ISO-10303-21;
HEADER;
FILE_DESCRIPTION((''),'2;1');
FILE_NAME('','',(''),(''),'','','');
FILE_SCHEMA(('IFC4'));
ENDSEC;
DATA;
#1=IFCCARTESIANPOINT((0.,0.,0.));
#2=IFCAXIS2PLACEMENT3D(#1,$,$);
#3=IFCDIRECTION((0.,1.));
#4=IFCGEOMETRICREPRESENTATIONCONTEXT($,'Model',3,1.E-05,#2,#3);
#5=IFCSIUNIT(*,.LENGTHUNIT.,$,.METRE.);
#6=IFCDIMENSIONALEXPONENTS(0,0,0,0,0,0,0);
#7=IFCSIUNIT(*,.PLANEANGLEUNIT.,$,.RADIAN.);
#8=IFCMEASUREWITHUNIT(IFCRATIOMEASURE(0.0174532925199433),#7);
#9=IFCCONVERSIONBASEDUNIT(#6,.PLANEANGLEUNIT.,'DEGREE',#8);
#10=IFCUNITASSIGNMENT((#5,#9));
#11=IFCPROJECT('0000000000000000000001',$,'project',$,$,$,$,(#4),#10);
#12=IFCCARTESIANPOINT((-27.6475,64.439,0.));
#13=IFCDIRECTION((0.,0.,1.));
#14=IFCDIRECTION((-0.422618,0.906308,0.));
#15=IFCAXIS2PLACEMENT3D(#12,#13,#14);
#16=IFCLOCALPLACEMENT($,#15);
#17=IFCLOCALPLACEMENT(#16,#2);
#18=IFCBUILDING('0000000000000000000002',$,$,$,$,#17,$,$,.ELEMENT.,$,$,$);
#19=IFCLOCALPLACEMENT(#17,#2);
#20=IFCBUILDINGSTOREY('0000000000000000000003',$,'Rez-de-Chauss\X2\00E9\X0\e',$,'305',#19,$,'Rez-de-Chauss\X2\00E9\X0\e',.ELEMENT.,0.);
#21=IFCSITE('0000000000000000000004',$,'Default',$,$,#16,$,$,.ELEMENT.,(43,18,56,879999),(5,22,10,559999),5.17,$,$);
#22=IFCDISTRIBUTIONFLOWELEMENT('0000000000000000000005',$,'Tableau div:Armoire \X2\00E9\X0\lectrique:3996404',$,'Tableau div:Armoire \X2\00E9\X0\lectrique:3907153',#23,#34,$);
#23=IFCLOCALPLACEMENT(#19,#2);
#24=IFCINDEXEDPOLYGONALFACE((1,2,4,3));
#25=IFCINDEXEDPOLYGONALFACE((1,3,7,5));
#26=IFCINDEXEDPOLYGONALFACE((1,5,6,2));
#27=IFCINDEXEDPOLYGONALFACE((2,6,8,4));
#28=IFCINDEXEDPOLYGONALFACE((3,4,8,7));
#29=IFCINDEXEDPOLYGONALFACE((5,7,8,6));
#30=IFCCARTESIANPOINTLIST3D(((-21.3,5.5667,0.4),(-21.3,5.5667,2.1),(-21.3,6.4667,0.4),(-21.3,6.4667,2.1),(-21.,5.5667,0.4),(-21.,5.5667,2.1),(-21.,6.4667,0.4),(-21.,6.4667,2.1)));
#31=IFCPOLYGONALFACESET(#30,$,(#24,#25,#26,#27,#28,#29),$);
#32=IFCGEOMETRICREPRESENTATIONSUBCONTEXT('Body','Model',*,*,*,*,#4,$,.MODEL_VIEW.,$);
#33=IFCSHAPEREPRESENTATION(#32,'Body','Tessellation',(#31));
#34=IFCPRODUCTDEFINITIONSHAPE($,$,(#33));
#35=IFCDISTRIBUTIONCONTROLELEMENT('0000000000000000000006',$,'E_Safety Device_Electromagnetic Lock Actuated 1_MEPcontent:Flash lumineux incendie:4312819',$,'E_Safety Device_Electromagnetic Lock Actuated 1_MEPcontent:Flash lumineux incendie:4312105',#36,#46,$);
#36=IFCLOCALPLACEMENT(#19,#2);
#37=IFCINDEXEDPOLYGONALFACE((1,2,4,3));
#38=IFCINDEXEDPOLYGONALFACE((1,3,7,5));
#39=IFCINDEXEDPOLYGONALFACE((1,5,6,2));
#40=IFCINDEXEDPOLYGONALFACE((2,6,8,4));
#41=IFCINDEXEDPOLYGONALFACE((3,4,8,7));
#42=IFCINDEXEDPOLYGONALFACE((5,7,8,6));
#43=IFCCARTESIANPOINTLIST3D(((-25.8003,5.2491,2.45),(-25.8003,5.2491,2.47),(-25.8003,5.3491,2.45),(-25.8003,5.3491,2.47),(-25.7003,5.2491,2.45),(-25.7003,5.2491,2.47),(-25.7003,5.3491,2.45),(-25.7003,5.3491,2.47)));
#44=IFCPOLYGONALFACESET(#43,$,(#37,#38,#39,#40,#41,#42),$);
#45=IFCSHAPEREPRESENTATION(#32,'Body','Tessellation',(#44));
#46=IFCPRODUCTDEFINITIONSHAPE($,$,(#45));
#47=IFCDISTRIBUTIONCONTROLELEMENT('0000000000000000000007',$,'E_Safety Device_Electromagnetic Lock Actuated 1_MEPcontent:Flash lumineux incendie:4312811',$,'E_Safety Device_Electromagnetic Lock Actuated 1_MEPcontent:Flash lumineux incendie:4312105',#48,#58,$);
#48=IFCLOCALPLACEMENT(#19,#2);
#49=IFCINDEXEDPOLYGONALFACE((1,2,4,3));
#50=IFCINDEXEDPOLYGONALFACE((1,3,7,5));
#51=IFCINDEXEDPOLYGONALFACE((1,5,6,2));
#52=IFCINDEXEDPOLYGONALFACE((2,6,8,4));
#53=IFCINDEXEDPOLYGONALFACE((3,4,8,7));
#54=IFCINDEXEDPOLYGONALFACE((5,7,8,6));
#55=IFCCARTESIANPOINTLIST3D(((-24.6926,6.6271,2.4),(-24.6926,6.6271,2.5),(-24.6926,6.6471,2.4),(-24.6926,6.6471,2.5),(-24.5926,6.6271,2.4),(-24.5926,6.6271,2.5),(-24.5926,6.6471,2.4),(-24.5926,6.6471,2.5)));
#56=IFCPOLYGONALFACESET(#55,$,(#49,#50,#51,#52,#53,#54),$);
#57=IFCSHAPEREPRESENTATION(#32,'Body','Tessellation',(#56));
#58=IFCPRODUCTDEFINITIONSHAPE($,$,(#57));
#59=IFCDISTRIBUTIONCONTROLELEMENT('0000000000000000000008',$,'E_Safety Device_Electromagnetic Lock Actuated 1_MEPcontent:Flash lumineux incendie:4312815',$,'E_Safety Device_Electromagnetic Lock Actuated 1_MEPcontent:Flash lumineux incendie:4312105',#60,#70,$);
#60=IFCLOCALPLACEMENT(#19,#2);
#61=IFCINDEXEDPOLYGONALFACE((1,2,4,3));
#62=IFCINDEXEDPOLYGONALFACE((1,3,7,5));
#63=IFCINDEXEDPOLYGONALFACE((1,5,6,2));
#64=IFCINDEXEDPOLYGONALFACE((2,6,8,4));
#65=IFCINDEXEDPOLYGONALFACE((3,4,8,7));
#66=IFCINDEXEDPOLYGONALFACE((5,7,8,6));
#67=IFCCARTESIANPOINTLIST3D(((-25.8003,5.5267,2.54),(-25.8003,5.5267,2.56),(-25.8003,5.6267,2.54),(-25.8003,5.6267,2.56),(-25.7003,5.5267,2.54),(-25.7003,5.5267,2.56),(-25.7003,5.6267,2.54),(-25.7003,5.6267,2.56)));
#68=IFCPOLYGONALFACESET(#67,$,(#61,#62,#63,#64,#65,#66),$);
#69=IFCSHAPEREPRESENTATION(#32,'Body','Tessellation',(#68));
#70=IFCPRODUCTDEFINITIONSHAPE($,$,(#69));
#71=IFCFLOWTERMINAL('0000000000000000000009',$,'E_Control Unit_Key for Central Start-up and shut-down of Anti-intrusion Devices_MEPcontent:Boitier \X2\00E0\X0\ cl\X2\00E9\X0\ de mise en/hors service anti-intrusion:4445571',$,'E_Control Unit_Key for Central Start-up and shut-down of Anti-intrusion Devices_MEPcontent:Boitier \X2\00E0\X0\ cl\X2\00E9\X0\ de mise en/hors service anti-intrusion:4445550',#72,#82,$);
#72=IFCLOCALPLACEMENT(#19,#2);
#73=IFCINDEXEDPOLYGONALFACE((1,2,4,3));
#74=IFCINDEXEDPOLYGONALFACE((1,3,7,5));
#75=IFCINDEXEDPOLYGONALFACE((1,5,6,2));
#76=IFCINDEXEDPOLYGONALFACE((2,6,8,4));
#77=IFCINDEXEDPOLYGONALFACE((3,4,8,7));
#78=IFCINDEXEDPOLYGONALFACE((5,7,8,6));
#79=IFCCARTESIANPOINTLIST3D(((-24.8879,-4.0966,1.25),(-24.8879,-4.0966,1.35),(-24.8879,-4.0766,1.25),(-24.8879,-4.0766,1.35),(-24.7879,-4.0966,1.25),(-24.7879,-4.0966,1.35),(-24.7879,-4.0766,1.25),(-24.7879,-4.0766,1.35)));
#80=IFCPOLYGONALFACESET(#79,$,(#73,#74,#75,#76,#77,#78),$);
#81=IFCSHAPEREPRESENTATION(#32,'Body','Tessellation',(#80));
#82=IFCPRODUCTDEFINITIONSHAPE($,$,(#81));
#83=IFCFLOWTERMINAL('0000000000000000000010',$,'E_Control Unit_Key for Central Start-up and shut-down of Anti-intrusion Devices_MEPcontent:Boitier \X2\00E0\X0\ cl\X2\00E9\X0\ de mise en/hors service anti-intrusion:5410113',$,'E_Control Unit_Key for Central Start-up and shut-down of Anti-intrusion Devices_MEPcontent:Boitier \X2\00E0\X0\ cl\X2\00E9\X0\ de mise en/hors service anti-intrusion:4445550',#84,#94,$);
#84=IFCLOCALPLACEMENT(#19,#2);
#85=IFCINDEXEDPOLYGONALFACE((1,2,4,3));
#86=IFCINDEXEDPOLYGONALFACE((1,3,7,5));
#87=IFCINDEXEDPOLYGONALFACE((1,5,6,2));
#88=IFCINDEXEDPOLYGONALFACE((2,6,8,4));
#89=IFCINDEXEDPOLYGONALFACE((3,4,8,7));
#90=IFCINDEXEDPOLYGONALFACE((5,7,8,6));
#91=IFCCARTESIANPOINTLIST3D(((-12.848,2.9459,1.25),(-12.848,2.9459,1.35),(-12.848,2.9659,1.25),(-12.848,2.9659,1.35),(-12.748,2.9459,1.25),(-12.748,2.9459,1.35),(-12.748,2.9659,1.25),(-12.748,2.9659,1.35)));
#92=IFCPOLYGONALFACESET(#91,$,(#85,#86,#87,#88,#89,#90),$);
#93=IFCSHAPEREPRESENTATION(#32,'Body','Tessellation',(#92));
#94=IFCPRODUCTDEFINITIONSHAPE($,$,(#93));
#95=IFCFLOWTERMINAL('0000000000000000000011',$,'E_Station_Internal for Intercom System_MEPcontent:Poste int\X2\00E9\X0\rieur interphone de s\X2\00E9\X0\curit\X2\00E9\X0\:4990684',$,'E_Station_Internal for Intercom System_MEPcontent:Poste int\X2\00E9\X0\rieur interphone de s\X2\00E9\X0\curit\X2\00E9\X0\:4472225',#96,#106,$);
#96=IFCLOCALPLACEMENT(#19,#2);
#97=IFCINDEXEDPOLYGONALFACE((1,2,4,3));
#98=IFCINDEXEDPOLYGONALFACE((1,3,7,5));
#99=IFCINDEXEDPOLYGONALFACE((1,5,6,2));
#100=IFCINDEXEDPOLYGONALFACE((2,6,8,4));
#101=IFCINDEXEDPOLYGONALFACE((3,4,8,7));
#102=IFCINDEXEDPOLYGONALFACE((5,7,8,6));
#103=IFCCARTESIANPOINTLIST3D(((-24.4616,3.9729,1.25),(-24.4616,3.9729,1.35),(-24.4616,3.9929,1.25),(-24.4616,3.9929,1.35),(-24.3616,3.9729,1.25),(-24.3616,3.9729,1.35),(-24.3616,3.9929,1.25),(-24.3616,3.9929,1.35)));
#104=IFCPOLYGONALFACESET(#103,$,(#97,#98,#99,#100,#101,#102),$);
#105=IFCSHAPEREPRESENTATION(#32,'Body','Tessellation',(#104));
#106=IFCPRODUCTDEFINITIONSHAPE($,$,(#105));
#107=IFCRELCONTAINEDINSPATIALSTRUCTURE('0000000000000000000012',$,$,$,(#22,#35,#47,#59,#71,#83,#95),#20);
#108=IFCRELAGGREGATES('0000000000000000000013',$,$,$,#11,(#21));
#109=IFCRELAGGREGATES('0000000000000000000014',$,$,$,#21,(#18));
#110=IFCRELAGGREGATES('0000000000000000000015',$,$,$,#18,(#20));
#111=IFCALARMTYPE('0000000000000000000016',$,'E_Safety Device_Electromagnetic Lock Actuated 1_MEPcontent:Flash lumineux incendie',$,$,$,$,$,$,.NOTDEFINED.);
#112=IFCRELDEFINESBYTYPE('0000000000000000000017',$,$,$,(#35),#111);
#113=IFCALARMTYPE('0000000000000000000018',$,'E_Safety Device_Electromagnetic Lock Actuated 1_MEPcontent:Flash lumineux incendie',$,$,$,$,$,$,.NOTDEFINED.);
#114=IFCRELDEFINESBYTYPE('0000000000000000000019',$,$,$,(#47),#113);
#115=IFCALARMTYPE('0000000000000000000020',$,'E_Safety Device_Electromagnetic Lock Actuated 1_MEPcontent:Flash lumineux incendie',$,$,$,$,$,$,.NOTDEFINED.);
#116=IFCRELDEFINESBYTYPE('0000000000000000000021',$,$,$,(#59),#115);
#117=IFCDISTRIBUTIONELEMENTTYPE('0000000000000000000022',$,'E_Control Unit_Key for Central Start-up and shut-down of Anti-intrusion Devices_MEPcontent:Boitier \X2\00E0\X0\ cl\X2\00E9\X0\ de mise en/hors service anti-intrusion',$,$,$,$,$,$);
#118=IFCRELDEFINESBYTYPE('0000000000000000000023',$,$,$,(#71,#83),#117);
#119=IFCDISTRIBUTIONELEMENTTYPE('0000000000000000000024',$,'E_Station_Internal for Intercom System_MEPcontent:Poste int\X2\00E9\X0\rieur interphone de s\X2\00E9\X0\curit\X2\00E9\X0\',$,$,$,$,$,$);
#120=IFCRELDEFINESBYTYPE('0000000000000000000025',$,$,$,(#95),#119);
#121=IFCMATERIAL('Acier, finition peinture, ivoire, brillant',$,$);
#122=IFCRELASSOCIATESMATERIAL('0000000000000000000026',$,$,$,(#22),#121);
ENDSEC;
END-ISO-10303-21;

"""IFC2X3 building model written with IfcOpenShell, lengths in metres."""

from ifc_helpers import new_model, entity, si_unit, converted_unit, direction, frame, frame_2d, origin, origin_2d_with_axis, place, context, subcontext, project, spatial, rectangle, extrude, source, transform, mapped, material, type_object, type_shapes, element, save


model = new_model("IFC2X3")

# Units and contexts
model_context = context("Model", 3, precision=1e-05, world=origin(), true_north=direction((0.0, 1.0)))
body_context = subcontext(model_context, "Body", "Model", "MODEL_VIEW")
ifc_project = project(units=[si_unit("LENGTHUNIT", "METRE"), converted_unit("PLANEANGLEUNIT", "DEGREE", entity("IfcRatioMeasure", 0.0174532925199433), si_unit("PLANEANGLEUNIT", "RADIAN"), dimensions=[0, 0, 0, 0, 0, 0, 0])], contexts=[model_context])

# Site, building, storey
site_placement = place(None, frame((-27.6475, 64.439, 0.0), z_axis=(0.0, 0.0, 1.0), x_axis=(-0.422618, 0.906308, 0.0)))
site = spatial("IfcSite", under=ifc_project, at=site_placement, Name="Default", CompositionType="ELEMENT", RefLatitude=(43, 18, 56, 879999), RefLongitude=(5, 22, 10, 559999), RefElevation=5.17)
building_placement = place(site_placement, origin())
building = spatial("IfcBuilding", under=site, at=building_placement, CompositionType="ELEMENT")
storey_placement = place(building_placement, origin())
storey = spatial("IfcBuildingStorey", under=building, at=storey_placement, Name="Rez-de-Chaussée", ObjectType="305", LongName="Rez-de-Chaussée", CompositionType="ELEMENT", Elevation=0.0)

# Distribution flow element
ifc_material_1 = material(Name="Acier, finition peinture, ivoire, brillant")
shared_shape_1 = source(origin(), body_context, "Body", "SweptSolid", [
    extrude(rectangle(XDim=0.9, YDim=0.3, at=origin_2d_with_axis()), frame((0.0, -0.45, 0.0), z_axis=(0.0, 0.0, 1.0), x_axis=(0.0, 1.0, 0.0)), (0.0, 0.0, 1.0), 1.7),
])
distribution_flow_element_placement = place(storey_placement, frame((-21.15, 5.5667, 0.4), z_axis=(0.0, 0.0, 1.0), x_axis=(-1.0, 0.0, 0.0)))
element("IfcDistributionFlowElement", 1, at=distribution_flow_element_placement, inside=storey, material=ifc_material_1, Name="Tableau div:Armoire électrique:3996404", ObjectType="Tableau div:Armoire électrique:3907153", context=body_context, shape_type="MappedRepresentation", body=[
    mapped(shared_shape_1, transform((0.0, 0.0, 0.0), scale=1.0)),
])

# Distribution control elements
alarm_type_1 = type_object("IfcAlarmType", Name="E_Safety Device_Electromagnetic Lock Actuated 1_MEPcontent:Flash lumineux incendie", PredefinedType="NOTDEFINED")
shared_shape_2 = source(origin(), body_context, "Body", "SweptSolid", [
    extrude(rectangle(XDim=0.1, YDim=0.1, at=origin_2d_with_axis()), frame((0.0, 0.0, 0.0), z_axis=(0.0, 0.0, 1.0), x_axis=(0.0, -1.0, 0.0)), (0.0, 0.0, 1.0), 0.02),
])
type_shapes(alarm_type_1, [shared_shape_2])
distribution_control_element_1_placement = place(storey_placement, frame((-25.7503, 5.2991, 2.45), z_axis=(0.0, 0.0, 1.0), x_axis=(0.0, -1.0, 0.0)))
element("IfcDistributionControlElement", 2, at=distribution_control_element_1_placement, inside=storey, type_object=alarm_type_1, Name="E_Safety Device_Electromagnetic Lock Actuated 1_MEPcontent:Flash lumineux incendie:4312819", ObjectType="E_Safety Device_Electromagnetic Lock Actuated 1_MEPcontent:Flash lumineux incendie:4312105", context=body_context, shape_type="MappedRepresentation", body=[
    mapped(shared_shape_2, transform((0.0, 0.0, 0.0), scale=1.0)),
])
alarm_type_2 = type_object("IfcAlarmType", Name="E_Safety Device_Electromagnetic Lock Actuated 1_MEPcontent:Flash lumineux incendie", PredefinedType="NOTDEFINED")
shared_shape_3 = source(origin(), body_context, "Body", "SweptSolid", [
    extrude(rectangle(XDim=0.02, YDim=0.1, at=frame_2d((0.0, 0.0), x_axis=(1.0, 0.0))), frame((0.01, 0.0, -0.05), z_axis=(0.0, 0.0, 1.0), x_axis=(-1.0, 0.0, 0.0)), (0.0, 0.0, 1.0), 0.1),
])
type_shapes(alarm_type_2, [shared_shape_3])
distribution_control_element_2_placement = place(storey_placement, frame((-24.6426, 6.6471, 2.45), z_axis=(0.0, 0.0, 1.0), x_axis=(0.0, -1.0, 0.0)))
element("IfcDistributionControlElement", 3, at=distribution_control_element_2_placement, inside=storey, type_object=alarm_type_2, Name="E_Safety Device_Electromagnetic Lock Actuated 1_MEPcontent:Flash lumineux incendie:4312811", ObjectType="E_Safety Device_Electromagnetic Lock Actuated 1_MEPcontent:Flash lumineux incendie:4312105", context=body_context, shape_type="MappedRepresentation", body=[
    mapped(shared_shape_3, transform((0.0, 0.0, 0.0), scale=1.0)),
])
alarm_type_3 = type_object("IfcAlarmType", Name="E_Safety Device_Electromagnetic Lock Actuated 1_MEPcontent:Flash lumineux incendie", PredefinedType="NOTDEFINED")
shared_shape_4 = source(origin(), body_context, "Body", "SweptSolid", [
    extrude(rectangle(XDim=0.1, YDim=0.1, at=origin_2d_with_axis()), frame((0.0, 0.0, -0.02)), (0.0, 0.0, 1.0), 0.02),
])
type_shapes(alarm_type_3, [shared_shape_4])
distribution_control_element_3_placement = place(storey_placement, frame((-25.7503, 5.5767, 2.56), z_axis=(0.0, 0.0, 1.0), x_axis=(0.0, -1.0, 0.0)))
element("IfcDistributionControlElement", 4, at=distribution_control_element_3_placement, inside=storey, type_object=alarm_type_3, Name="E_Safety Device_Electromagnetic Lock Actuated 1_MEPcontent:Flash lumineux incendie:4312815", ObjectType="E_Safety Device_Electromagnetic Lock Actuated 1_MEPcontent:Flash lumineux incendie:4312105", context=body_context, shape_type="MappedRepresentation", body=[
    mapped(shared_shape_4, transform((0.0, 0.0, 0.0), scale=1.0)),
])

# Flow terminals
distribution_element_type_1 = type_object("IfcDistributionElementType", Name="E_Control Unit_Key for Central Start-up and shut-down of Anti-intrusion Devices_MEPcontent:Boitier à clé de mise en/hors service anti-intrusion")
shared_shape_5 = source(origin(), body_context, "Body", "SweptSolid", [
    extrude(rectangle(XDim=0.02, YDim=0.1, at=frame_2d((0.0, 0.0), x_axis=(1.0, 0.0))), frame((0.0, -0.01, -0.05), z_axis=(0.0, 0.0, 1.0), x_axis=(0.0, 1.0, 0.0)), (0.0, 0.0, 1.0), 0.1),
])
type_shapes(distribution_element_type_1, [shared_shape_5])
flow_terminal_1_placement = place(storey_placement, frame((-24.8379, -4.0966, 1.3), z_axis=(0.0, 0.0, 1.0), x_axis=(-1.0, 0.0, 0.0)))
element("IfcFlowTerminal", 5, at=flow_terminal_1_placement, inside=storey, type_object=distribution_element_type_1, Name="E_Control Unit_Key for Central Start-up and shut-down of Anti-intrusion Devices_MEPcontent:Boitier à clé de mise en/hors service anti-intrusion:4445571", ObjectType="E_Control Unit_Key for Central Start-up and shut-down of Anti-intrusion Devices_MEPcontent:Boitier à clé de mise en/hors service anti-intrusion:4445550", context=body_context, shape_type="MappedRepresentation", body=[
    mapped(shared_shape_5, transform((0.0, 0.0, 0.0), scale=1.0)),
])
flow_terminal_2_placement = place(storey_placement, frame((-12.798, 2.9659, 1.3)))
element("IfcFlowTerminal", 6, at=flow_terminal_2_placement, inside=storey, type_object=distribution_element_type_1, Name="E_Control Unit_Key for Central Start-up and shut-down of Anti-intrusion Devices_MEPcontent:Boitier à clé de mise en/hors service anti-intrusion:5410113", ObjectType="E_Control Unit_Key for Central Start-up and shut-down of Anti-intrusion Devices_MEPcontent:Boitier à clé de mise en/hors service anti-intrusion:4445550", context=body_context, shape_type="MappedRepresentation", body=[
    mapped(shared_shape_5, transform((0.0, 0.0, 0.0), scale=1.0)),
])
distribution_element_type_2 = type_object("IfcDistributionElementType", Name="E_Station_Internal for Intercom System_MEPcontent:Poste intérieur interphone de sécurité")
shared_shape_6 = source(origin(), body_context, "Body", "SweptSolid", [
    extrude(rectangle(XDim=0.02, YDim=0.1, at=frame_2d((0.0, 0.0), x_axis=(1.0, 0.0))), frame((0.0, -0.01, -0.05), z_axis=(0.0, 0.0, 1.0), x_axis=(0.0, 1.0, 0.0)), (0.0, 0.0, 1.0), 0.1),
])
type_shapes(distribution_element_type_2, [shared_shape_6])
flow_terminal_3_placement = place(storey_placement, frame((-24.4116, 3.9929, 1.3)))
element("IfcFlowTerminal", 7, at=flow_terminal_3_placement, inside=storey, type_object=distribution_element_type_2, Name="E_Station_Internal for Intercom System_MEPcontent:Poste intérieur interphone de sécurité:4990684", ObjectType="E_Station_Internal for Intercom System_MEPcontent:Poste intérieur interphone de sécurité:4472225", context=body_context, shape_type="MappedRepresentation", body=[
    mapped(shared_shape_6, transform((0.0, 0.0, 0.0), scale=1.0)),
])

save(model, "model.ifc")
